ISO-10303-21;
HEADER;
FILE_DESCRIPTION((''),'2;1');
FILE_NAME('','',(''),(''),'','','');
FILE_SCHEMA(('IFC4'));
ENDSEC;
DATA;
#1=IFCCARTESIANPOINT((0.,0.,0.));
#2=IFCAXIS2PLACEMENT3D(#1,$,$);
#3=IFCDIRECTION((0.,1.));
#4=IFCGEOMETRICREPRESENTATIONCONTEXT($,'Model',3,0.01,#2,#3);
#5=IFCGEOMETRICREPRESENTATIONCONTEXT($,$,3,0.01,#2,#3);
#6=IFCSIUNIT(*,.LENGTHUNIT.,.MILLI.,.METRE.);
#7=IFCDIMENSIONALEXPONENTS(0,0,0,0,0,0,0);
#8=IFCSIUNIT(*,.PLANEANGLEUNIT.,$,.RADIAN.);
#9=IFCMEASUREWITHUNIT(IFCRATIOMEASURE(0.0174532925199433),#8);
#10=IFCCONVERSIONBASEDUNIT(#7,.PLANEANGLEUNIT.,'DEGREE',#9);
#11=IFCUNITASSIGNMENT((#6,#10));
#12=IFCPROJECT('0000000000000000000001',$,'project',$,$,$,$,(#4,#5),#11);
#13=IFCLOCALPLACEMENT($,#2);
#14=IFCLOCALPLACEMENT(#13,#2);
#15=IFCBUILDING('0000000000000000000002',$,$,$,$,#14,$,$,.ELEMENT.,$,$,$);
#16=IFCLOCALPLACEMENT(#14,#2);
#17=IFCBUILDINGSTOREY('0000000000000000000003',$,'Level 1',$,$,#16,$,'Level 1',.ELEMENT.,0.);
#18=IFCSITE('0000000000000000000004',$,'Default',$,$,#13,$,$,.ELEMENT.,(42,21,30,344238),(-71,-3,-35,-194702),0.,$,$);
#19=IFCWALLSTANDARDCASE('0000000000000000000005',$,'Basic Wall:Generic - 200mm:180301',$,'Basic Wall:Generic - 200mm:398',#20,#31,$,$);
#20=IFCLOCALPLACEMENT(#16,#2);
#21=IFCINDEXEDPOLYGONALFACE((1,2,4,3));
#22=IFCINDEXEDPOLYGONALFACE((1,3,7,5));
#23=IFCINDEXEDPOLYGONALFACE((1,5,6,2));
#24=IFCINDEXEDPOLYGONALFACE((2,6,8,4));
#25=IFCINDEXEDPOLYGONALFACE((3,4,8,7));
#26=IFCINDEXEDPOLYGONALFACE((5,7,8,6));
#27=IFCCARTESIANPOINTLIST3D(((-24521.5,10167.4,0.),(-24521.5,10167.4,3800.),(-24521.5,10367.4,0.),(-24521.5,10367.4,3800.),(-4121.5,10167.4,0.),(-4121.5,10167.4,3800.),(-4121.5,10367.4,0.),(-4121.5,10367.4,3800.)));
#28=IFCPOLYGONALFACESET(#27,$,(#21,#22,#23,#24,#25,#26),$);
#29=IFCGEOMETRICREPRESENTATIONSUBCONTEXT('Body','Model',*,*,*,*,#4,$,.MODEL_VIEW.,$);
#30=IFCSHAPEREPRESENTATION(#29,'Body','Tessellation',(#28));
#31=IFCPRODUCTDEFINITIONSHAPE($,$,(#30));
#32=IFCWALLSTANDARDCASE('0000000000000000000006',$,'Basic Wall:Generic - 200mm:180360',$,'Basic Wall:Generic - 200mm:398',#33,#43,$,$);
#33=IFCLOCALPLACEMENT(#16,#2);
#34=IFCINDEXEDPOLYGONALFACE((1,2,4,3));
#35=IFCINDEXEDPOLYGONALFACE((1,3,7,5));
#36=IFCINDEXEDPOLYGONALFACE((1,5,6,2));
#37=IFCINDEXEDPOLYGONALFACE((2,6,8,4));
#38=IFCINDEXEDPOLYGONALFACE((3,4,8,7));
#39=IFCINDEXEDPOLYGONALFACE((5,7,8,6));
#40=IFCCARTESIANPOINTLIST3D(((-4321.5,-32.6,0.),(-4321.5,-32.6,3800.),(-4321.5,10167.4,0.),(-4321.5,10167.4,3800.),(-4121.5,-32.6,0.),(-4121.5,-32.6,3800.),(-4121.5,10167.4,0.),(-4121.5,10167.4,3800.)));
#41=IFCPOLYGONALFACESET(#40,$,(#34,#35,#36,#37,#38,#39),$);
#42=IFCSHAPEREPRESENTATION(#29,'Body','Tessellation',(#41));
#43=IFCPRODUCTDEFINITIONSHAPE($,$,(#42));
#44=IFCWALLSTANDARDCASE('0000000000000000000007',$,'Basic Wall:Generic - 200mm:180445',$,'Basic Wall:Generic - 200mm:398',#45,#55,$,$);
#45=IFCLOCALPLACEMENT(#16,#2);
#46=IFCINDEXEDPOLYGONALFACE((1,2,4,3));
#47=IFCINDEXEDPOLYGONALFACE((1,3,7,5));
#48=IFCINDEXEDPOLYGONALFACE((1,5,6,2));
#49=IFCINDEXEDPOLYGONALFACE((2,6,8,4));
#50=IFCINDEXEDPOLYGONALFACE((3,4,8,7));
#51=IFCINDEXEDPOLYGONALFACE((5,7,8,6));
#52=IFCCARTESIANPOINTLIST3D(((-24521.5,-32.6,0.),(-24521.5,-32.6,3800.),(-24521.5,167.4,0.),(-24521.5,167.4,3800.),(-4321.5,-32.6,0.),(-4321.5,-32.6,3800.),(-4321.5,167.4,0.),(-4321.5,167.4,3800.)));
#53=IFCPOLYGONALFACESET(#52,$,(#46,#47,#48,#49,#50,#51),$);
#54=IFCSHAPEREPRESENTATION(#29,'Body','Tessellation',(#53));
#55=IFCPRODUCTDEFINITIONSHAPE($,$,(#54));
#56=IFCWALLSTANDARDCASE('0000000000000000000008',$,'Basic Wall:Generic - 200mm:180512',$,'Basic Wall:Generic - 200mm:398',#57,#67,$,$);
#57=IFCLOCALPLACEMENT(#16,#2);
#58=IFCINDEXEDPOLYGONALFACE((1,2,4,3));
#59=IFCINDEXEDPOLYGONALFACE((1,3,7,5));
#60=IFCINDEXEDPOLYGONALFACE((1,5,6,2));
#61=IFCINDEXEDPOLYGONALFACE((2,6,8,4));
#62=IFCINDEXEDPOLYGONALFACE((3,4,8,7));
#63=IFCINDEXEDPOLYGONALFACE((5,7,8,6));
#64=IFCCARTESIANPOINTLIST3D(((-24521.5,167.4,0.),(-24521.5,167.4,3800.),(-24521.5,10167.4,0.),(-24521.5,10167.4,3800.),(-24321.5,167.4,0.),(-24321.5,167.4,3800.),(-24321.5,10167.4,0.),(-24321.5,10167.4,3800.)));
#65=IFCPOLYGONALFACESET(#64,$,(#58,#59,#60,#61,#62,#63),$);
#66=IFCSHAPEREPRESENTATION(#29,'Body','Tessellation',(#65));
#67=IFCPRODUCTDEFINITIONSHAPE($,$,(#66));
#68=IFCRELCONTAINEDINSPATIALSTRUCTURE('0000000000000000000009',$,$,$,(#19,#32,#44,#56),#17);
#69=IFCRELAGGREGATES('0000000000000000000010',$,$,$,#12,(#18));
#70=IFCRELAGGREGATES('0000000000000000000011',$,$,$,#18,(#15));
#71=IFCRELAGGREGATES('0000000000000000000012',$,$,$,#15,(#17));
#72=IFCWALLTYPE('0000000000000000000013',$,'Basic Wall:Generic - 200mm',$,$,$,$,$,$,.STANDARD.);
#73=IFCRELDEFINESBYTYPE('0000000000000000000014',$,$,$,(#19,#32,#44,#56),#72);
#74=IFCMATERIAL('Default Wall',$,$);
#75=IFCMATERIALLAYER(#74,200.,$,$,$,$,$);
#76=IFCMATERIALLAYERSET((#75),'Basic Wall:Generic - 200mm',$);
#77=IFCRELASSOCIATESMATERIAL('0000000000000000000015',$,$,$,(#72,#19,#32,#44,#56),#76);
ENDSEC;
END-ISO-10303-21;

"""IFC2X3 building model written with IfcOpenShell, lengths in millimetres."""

from ifc_helpers import new_model, entity, si_unit, converted_unit, direction, frame, frame_2d, origin, place, context, subcontext, project, spatial, rectangle, extrude, material, layer, layer_set, layer_usage, type_object, element, save


model = new_model("IFC2X3")

# Units and contexts
model_context = context("Model", 3, precision=0.01, world=origin(), true_north=direction((0.0, 1.0)))
context_of_model = context(None, 3, precision=0.01, world=origin(), true_north=direction((0.0, 1.0)))
body_context = subcontext(model_context, "Body", "Model", "MODEL_VIEW")
ifc_project = project(units=[si_unit("LENGTHUNIT", "METRE", prefix="MILLI"), converted_unit("PLANEANGLEUNIT", "DEGREE", entity("IfcRatioMeasure", 0.0174532925199433), si_unit("PLANEANGLEUNIT", "RADIAN"), dimensions=[0, 0, 0, 0, 0, 0, 0])], contexts=[model_context, context_of_model])

# Site, building, storey
site_placement = place(None, origin())
site = spatial("IfcSite", under=ifc_project, at=site_placement, Name="Default", CompositionType="ELEMENT", RefLatitude=(42, 21, 30, 344238), RefLongitude=(-71, -3, -35, -194702), RefElevation=0.0)
building_placement = place(site_placement, origin())
building = spatial("IfcBuilding", under=site, at=building_placement, CompositionType="ELEMENT")
storey_placement = place(building_placement, origin())
storey = spatial("IfcBuildingStorey", under=building, at=storey_placement, Name="Level 1", LongName="Level 1", CompositionType="ELEMENT", Elevation=0.0)

# Walls
ifc_material = material(Name="Default Wall")
ifc_layer = layer(ifc_material, 200.0)
ifc_layer_set = layer_set([ifc_layer], Name="Basic Wall:Generic - 200mm")
ifc_layer_usage_1 = layer_usage(ifc_layer_set, "AXIS2", "NEGATIVE", 100.0)
wall_type = type_object("IfcWallType", Name="Basic Wall:Generic - 200mm", PredefinedType="STANDARD", material=ifc_layer_set)
wall_1_placement = place(storey_placement, frame((-24521.5, 10267.4, 0.0)))
element("IfcWallStandardCase", 1, at=wall_1_placement, inside=storey, type_object=wall_type, material=ifc_layer_usage_1, Name="Basic Wall:Generic - 200mm:180301", ObjectType="Basic Wall:Generic - 200mm:398", context=body_context, shape_type="SweptSolid", body=[
    extrude(rectangle(XDim=20400.0, YDim=200.0, at=frame_2d((10200.0, 0.0), x_axis=(-1.0, 0.0))), origin(), (0.0, 0.0, 1.0), 3800.0),
])
ifc_layer_usage_2 = layer_usage(ifc_layer_set, "AXIS2", "NEGATIVE", 100.0)
wall_2_placement = place(storey_placement, frame((-4221.5, 10167.4, 0.0), z_axis=(0.0, 0.0, 1.0), x_axis=(0.0, -1.0, 0.0)))
element("IfcWallStandardCase", 2, at=wall_2_placement, inside=storey, type_object=wall_type, material=ifc_layer_usage_2, Name="Basic Wall:Generic - 200mm:180360", ObjectType="Basic Wall:Generic - 200mm:398", context=body_context, shape_type="SweptSolid", body=[
    extrude(rectangle(XDim=10200.0, YDim=200.0, at=frame_2d((5100.0, 0.0), x_axis=(-1.0, 0.0))), origin(), (0.0, 0.0, 1.0), 3800.0),
])
ifc_layer_usage_3 = layer_usage(ifc_layer_set, "AXIS2", "NEGATIVE", 100.0)
wall_3_placement = place(storey_placement, frame((-4321.5, 67.4, 0.0), z_axis=(0.0, 0.0, 1.0), x_axis=(-1.0, 0.0, 0.0)))
element("IfcWallStandardCase", 3, at=wall_3_placement, inside=storey, type_object=wall_type, material=ifc_layer_usage_3, Name="Basic Wall:Generic - 200mm:180445", ObjectType="Basic Wall:Generic - 200mm:398", context=body_context, shape_type="SweptSolid", body=[
    extrude(rectangle(XDim=20200.0, YDim=200.0, at=frame_2d((10100.0, 0.0), x_axis=(-1.0, 0.0))), origin(), (0.0, 0.0, 1.0), 3800.0),
])
ifc_layer_usage_4 = layer_usage(ifc_layer_set, "AXIS2", "NEGATIVE", 100.0)
wall_4_placement = place(storey_placement, frame((-24421.5, 167.4, 0.0), z_axis=(0.0, 0.0, 1.0), x_axis=(0.0, 1.0, 0.0)))
element("IfcWallStandardCase", 4, at=wall_4_placement, inside=storey, type_object=wall_type, material=ifc_layer_usage_4, Name="Basic Wall:Generic - 200mm:180512", ObjectType="Basic Wall:Generic - 200mm:398", context=body_context, shape_type="SweptSolid", body=[
    extrude(rectangle(XDim=10000.0, YDim=200.0, at=frame_2d((5000.0, 0.0), x_axis=(-1.0, 0.0))), origin(), (0.0, 0.0, 1.0), 3800.0),
])

save(model, "model.ifc")
